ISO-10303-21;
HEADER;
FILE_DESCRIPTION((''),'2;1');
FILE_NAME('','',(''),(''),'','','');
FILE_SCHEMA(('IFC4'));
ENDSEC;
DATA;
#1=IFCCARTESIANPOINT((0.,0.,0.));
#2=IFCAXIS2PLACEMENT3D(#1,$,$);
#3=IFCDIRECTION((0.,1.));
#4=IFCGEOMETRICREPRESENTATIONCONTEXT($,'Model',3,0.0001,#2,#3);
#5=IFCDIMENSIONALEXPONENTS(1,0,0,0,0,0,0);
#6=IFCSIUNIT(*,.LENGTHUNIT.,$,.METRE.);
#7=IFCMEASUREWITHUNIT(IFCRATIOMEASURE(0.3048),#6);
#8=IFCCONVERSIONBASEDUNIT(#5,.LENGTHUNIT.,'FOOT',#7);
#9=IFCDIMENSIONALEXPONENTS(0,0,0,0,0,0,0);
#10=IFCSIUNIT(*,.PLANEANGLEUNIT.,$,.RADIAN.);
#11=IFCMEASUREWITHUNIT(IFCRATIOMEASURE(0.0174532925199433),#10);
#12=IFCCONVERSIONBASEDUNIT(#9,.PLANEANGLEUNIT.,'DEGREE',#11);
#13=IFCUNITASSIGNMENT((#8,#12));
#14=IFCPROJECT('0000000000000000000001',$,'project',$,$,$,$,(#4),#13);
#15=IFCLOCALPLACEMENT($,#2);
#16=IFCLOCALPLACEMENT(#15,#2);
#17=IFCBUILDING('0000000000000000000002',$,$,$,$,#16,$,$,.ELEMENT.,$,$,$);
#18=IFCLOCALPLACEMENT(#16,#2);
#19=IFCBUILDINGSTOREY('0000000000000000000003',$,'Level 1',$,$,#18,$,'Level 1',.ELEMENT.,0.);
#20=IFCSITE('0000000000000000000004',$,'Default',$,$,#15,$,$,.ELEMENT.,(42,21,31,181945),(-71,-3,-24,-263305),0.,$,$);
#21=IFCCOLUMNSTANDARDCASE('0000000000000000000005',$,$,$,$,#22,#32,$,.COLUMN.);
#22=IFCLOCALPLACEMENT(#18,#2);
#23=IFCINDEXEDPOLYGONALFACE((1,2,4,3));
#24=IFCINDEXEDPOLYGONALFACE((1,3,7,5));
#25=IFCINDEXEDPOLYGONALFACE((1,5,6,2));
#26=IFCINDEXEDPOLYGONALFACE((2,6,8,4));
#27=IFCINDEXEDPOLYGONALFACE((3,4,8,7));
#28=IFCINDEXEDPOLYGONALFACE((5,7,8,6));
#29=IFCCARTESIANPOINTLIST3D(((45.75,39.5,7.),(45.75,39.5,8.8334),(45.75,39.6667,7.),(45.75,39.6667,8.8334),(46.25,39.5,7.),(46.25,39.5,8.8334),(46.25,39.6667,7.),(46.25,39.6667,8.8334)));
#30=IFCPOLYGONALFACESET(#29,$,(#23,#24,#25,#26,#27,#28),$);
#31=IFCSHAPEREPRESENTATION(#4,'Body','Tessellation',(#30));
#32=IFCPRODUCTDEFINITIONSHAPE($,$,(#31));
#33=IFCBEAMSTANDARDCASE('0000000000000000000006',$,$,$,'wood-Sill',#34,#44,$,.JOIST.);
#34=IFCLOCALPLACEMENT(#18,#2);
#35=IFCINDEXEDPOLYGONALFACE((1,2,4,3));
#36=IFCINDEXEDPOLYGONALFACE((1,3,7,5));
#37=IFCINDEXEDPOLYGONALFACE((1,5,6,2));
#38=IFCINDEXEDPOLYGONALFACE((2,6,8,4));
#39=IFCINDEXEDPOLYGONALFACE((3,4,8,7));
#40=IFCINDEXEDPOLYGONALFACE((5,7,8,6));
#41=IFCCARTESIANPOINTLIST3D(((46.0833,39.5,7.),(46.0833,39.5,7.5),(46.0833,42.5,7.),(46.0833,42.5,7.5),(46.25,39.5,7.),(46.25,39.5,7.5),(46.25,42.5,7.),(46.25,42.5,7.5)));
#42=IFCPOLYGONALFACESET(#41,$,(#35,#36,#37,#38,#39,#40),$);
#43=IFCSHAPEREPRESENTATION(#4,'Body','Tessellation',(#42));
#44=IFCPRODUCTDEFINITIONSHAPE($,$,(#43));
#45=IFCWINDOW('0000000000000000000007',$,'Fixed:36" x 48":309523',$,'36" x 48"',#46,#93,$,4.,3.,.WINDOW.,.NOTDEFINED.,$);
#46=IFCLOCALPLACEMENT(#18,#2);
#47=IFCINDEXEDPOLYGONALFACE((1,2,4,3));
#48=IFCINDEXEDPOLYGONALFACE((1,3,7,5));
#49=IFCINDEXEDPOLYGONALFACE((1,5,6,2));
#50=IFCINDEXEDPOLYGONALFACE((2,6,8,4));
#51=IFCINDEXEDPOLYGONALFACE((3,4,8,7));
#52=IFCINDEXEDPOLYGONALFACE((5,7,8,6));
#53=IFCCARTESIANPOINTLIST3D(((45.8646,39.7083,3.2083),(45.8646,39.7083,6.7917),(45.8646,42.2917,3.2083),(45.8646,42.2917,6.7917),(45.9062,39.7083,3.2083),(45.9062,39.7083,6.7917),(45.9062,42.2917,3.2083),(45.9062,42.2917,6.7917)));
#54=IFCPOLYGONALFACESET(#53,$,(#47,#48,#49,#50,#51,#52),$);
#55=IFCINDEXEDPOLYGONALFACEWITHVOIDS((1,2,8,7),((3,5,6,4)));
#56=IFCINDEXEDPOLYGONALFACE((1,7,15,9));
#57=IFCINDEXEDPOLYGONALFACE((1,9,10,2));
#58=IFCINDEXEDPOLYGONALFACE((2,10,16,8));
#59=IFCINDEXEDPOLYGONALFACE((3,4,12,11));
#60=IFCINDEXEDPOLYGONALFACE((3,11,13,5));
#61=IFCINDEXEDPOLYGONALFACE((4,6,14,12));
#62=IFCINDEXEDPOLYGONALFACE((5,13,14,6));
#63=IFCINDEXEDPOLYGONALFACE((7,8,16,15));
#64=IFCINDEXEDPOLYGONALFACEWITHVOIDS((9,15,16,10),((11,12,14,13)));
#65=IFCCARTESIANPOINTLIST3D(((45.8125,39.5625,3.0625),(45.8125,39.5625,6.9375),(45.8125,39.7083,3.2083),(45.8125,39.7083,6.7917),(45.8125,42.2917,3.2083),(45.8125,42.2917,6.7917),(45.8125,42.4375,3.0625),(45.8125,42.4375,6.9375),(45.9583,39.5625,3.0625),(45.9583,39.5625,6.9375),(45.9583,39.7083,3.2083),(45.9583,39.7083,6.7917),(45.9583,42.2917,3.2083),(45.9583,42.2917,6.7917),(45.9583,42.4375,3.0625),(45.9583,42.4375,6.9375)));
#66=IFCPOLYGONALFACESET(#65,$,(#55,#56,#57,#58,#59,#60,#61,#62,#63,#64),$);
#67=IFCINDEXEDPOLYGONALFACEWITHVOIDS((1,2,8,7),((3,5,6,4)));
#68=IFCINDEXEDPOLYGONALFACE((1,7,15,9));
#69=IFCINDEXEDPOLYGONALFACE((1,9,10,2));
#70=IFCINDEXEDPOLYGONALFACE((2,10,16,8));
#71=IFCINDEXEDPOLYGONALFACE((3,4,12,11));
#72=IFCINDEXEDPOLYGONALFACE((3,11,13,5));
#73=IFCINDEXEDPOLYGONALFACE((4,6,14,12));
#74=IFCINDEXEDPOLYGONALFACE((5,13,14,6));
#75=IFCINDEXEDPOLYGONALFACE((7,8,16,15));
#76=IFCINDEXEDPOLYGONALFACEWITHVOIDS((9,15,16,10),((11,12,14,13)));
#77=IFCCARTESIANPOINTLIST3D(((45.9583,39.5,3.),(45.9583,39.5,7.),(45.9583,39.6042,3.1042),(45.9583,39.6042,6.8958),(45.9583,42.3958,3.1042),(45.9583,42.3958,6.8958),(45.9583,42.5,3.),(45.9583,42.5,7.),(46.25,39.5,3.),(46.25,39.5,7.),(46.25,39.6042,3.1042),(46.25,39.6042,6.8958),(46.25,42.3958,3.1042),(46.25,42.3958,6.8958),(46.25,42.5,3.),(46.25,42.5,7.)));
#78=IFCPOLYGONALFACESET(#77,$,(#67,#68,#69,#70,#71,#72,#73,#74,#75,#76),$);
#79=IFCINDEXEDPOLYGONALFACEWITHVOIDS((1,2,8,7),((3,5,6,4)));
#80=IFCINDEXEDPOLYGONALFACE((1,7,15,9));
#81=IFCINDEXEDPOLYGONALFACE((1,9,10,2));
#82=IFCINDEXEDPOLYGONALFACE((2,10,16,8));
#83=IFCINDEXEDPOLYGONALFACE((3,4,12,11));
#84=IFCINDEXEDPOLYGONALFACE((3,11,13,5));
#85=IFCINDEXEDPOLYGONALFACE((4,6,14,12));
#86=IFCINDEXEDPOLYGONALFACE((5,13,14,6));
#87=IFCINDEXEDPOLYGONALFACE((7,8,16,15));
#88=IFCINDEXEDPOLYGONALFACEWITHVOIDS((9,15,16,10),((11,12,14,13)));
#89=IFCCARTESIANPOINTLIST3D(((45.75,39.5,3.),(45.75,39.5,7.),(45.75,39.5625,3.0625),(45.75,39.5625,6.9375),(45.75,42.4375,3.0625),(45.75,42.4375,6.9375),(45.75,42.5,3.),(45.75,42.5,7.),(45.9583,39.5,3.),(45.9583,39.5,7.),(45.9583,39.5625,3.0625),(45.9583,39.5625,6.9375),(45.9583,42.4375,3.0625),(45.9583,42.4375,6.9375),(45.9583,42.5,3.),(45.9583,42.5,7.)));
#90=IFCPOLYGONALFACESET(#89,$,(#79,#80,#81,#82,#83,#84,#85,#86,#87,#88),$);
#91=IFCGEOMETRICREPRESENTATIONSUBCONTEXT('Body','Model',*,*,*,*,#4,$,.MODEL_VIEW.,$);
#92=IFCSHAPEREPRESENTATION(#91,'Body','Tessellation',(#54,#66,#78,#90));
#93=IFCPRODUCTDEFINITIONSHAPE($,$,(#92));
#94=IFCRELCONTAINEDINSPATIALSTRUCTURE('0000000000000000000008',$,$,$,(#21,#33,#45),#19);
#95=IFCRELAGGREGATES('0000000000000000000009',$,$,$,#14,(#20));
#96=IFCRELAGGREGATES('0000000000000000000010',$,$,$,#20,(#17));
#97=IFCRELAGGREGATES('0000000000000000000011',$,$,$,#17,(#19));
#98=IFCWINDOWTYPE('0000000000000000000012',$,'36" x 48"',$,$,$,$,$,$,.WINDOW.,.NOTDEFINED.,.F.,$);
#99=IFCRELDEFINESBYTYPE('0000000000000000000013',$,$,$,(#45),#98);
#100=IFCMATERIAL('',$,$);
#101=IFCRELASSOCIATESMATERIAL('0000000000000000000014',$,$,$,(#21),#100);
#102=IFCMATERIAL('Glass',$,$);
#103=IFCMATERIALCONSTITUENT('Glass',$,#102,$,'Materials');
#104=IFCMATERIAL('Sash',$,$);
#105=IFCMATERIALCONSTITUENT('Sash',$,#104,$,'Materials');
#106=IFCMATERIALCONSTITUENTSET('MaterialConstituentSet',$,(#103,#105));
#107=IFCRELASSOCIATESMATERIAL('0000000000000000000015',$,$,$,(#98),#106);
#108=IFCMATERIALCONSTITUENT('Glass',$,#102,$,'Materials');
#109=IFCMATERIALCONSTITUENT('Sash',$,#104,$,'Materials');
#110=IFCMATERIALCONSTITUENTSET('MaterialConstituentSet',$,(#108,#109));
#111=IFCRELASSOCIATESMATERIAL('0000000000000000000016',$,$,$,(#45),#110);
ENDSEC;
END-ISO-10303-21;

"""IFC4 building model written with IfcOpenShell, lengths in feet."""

from ifc_helpers import new_model, entity, si_unit, converted_unit, direction, frame, frame_2d, origin, origin_with_axes, place, context, subcontext, project, spatial, polyline, rectangle, outline, extrude, source, transform, mapped, material, constituent, constituent_set, type_object, type_shapes, element, save


model = new_model("IFC4")

# Units and contexts
model_context = context("Model", 3, precision=0.0001, world=origin(), true_north=direction((0.0, 1.0)))
body_context = subcontext(model_context, "Body", "Model", "MODEL_VIEW")
ifc_project = project(units=[converted_unit("LENGTHUNIT", "FOOT", entity("IfcRatioMeasure", 0.3048), si_unit("LENGTHUNIT", "METRE"), dimensions=[1, 0, 0, 0, 0, 0, 0]), converted_unit("PLANEANGLEUNIT", "DEGREE", entity("IfcRatioMeasure", 0.0174532925199433), si_unit("PLANEANGLEUNIT", "RADIAN"), dimensions=[0, 0, 0, 0, 0, 0, 0])], contexts=[model_context])

# Site, building, storey
site_placement = place(None, origin())
site = spatial("IfcSite", under=ifc_project, at=site_placement, Name="Default", CompositionType="ELEMENT", RefLatitude=(42, 21, 31, 181945), RefLongitude=(-71, -3, -24, -263305), RefElevation=0.0)
building_placement = place(site_placement, origin())
building = spatial("IfcBuilding", under=site, at=building_placement, CompositionType="ELEMENT")
storey_placement = place(building_placement, origin())
storey = spatial("IfcBuildingStorey", under=building, at=storey_placement, Name="Level 1", LongName="Level 1", CompositionType="ELEMENT", Elevation=0.0)

# Column
placement_1 = place(storey_placement, frame((46.0, 46.25, 0.0), z_axis=(0.0, 0.0, 1.0), x_axis=(0.0, -1.0, 0.0)))
ifc_material_1 = material(Name="")
for number, where, z_axis, x_axis in (
    (1, (6.6667, 0.0, 7.0), (0.0, 0.0, 1.0), (1.0, 0.0, 0.0)),
):
    element("IfcColumnStandardCase", number, at=place(placement_1, frame(where, z_axis=z_axis, x_axis=x_axis)), inside=storey, material=ifc_material_1, PredefinedType="COLUMN", context=model_context, shape_type="SweptSolid", body=[
        extrude(rectangle(XDim=0.1667, YDim=0.5), origin(), (0.0, 0.0, 1.0), 1.8334),
    ])

# Beam
for number, where, z_axis, x_axis in (
    (2, (3.75, 0.1667, 7.25), (1.0, 0.0, 0.0), (0.0, 0.0, 1.0)),
):
    element("IfcBeamStandardCase", number, at=place(placement_1, frame(where, z_axis=z_axis, x_axis=x_axis)), inside=storey, ObjectType="wood-Sill", PredefinedType="JOIST", context=model_context, shape_type="SweptSolid", body=[
        extrude(rectangle(XDim=0.5, YDim=0.1667), origin_with_axes(), (0.0, 0.0, 1.0), 3.0),
    ])

# Window
ifc_material_2 = material(Name="Glass")
ifc_constituent_1 = constituent(ifc_material_2, Name="Glass", Category="Materials")
ifc_material_3 = material(Name="Sash")
ifc_constituent_2 = constituent(ifc_material_3, Name="Sash", Category="Materials")
ifc_constituent_set_1 = constituent_set(constituents=[ifc_constituent_1, ifc_constituent_2], Name="MaterialConstituentSet")
ifc_constituent_3 = constituent(ifc_material_2, Name="Glass", Category="Materials")
ifc_constituent_4 = constituent(ifc_material_3, Name="Sash", Category="Materials")
ifc_constituent_set_2 = constituent_set(constituents=[ifc_constituent_3, ifc_constituent_4], Name="MaterialConstituentSet")
window_type = type_object("IfcWindowType", Name="36\" x 48\"", ParameterTakesPrecedence=False, PartitioningType="NOTDEFINED", PredefinedType="WINDOW", material=ifc_constituent_set_2)
shared_shape = source(origin(), body_context, "Body", "SweptSolid", [
    extrude(rectangle(XDim=0.0417, YDim=2.5833, at=frame_2d((0.0, 0.0), x_axis=(1.0, 0.0))), frame((1.5, 0.3646, 0.2083), z_axis=(0.0, 0.0, 1.0), x_axis=(0.0, 1.0, 0.0)), (0.0, 0.0, 1.0), 3.5833),
    extrude(outline(polyline([(-1.4375, -1.9375), (1.4375, -1.9375), (1.4375, 1.9375), (-1.4375, 1.9375), (-1.4375, -1.9375)]), holes=[polyline([(-1.2917, -1.7917), (-1.2917, 1.7917), (1.2917, 1.7917), (1.2917, -1.7917), (-1.2917, -1.7917)])]), frame((1.5, 0.2917, 2.0), z_axis=(0.0, 1.0, 0.0), x_axis=(1.0, 0.0, 0.0)), (0.0, 0.0, 1.0), 0.1458),
    extrude(outline(polyline([(-1.5, -2.0), (1.5, -2.0), (1.5, 2.0), (-1.5, 2.0), (-1.5, -2.0)]), holes=[polyline([(-1.3958, -1.8958), (-1.3958, 1.8958), (1.3958, 1.8958), (1.3958, -1.8958), (-1.3958, -1.8958)])]), frame((1.5, 0.0, 2.0), z_axis=(0.0, 1.0, 0.0), x_axis=(1.0, 0.0, 0.0)), (0.0, 0.0, 1.0), 0.2917),
    extrude(outline(polyline([(-2.0, -1.5), (2.0, -1.5), (2.0, 1.5), (-2.0, 1.5), (-2.0, -1.5)]), holes=[polyline([(-1.9375, -1.4375), (-1.9375, 1.4375), (1.9375, 1.4375), (1.9375, -1.4375), (-1.9375, -1.4375)])]), frame((1.5, 0.2917, 2.0), z_axis=(0.0, 1.0, 0.0), x_axis=(0.0, 0.0, -1.0)), (0.0, 0.0, 1.0), 0.2083),
])
type_shapes(window_type, [shared_shape])
placement_2 = place(placement_1, frame((6.75, 0.25, 3.0)))
window_placement = place(placement_2, frame((0.0, 0.0, 0.0), z_axis=(0.0, 0.0, 1.0), x_axis=(-1.0, 0.0, 0.0)))
element("IfcWindow", 3, at=window_placement, inside=storey, type_object=window_type, material=ifc_constituent_set_1, Name="Fixed:36\" x 48\":309523", ObjectType="36\" x 48\"", OverallHeight=4.0, OverallWidth=3.0, PartitioningType="NOTDEFINED", PredefinedType="WINDOW", context=body_context, shape_type="MappedRepresentation", body=[
    mapped(shared_shape, transform((0.0, 0.0, 0.0), scale=1.0)),
])

save(model, "model.ifc")
